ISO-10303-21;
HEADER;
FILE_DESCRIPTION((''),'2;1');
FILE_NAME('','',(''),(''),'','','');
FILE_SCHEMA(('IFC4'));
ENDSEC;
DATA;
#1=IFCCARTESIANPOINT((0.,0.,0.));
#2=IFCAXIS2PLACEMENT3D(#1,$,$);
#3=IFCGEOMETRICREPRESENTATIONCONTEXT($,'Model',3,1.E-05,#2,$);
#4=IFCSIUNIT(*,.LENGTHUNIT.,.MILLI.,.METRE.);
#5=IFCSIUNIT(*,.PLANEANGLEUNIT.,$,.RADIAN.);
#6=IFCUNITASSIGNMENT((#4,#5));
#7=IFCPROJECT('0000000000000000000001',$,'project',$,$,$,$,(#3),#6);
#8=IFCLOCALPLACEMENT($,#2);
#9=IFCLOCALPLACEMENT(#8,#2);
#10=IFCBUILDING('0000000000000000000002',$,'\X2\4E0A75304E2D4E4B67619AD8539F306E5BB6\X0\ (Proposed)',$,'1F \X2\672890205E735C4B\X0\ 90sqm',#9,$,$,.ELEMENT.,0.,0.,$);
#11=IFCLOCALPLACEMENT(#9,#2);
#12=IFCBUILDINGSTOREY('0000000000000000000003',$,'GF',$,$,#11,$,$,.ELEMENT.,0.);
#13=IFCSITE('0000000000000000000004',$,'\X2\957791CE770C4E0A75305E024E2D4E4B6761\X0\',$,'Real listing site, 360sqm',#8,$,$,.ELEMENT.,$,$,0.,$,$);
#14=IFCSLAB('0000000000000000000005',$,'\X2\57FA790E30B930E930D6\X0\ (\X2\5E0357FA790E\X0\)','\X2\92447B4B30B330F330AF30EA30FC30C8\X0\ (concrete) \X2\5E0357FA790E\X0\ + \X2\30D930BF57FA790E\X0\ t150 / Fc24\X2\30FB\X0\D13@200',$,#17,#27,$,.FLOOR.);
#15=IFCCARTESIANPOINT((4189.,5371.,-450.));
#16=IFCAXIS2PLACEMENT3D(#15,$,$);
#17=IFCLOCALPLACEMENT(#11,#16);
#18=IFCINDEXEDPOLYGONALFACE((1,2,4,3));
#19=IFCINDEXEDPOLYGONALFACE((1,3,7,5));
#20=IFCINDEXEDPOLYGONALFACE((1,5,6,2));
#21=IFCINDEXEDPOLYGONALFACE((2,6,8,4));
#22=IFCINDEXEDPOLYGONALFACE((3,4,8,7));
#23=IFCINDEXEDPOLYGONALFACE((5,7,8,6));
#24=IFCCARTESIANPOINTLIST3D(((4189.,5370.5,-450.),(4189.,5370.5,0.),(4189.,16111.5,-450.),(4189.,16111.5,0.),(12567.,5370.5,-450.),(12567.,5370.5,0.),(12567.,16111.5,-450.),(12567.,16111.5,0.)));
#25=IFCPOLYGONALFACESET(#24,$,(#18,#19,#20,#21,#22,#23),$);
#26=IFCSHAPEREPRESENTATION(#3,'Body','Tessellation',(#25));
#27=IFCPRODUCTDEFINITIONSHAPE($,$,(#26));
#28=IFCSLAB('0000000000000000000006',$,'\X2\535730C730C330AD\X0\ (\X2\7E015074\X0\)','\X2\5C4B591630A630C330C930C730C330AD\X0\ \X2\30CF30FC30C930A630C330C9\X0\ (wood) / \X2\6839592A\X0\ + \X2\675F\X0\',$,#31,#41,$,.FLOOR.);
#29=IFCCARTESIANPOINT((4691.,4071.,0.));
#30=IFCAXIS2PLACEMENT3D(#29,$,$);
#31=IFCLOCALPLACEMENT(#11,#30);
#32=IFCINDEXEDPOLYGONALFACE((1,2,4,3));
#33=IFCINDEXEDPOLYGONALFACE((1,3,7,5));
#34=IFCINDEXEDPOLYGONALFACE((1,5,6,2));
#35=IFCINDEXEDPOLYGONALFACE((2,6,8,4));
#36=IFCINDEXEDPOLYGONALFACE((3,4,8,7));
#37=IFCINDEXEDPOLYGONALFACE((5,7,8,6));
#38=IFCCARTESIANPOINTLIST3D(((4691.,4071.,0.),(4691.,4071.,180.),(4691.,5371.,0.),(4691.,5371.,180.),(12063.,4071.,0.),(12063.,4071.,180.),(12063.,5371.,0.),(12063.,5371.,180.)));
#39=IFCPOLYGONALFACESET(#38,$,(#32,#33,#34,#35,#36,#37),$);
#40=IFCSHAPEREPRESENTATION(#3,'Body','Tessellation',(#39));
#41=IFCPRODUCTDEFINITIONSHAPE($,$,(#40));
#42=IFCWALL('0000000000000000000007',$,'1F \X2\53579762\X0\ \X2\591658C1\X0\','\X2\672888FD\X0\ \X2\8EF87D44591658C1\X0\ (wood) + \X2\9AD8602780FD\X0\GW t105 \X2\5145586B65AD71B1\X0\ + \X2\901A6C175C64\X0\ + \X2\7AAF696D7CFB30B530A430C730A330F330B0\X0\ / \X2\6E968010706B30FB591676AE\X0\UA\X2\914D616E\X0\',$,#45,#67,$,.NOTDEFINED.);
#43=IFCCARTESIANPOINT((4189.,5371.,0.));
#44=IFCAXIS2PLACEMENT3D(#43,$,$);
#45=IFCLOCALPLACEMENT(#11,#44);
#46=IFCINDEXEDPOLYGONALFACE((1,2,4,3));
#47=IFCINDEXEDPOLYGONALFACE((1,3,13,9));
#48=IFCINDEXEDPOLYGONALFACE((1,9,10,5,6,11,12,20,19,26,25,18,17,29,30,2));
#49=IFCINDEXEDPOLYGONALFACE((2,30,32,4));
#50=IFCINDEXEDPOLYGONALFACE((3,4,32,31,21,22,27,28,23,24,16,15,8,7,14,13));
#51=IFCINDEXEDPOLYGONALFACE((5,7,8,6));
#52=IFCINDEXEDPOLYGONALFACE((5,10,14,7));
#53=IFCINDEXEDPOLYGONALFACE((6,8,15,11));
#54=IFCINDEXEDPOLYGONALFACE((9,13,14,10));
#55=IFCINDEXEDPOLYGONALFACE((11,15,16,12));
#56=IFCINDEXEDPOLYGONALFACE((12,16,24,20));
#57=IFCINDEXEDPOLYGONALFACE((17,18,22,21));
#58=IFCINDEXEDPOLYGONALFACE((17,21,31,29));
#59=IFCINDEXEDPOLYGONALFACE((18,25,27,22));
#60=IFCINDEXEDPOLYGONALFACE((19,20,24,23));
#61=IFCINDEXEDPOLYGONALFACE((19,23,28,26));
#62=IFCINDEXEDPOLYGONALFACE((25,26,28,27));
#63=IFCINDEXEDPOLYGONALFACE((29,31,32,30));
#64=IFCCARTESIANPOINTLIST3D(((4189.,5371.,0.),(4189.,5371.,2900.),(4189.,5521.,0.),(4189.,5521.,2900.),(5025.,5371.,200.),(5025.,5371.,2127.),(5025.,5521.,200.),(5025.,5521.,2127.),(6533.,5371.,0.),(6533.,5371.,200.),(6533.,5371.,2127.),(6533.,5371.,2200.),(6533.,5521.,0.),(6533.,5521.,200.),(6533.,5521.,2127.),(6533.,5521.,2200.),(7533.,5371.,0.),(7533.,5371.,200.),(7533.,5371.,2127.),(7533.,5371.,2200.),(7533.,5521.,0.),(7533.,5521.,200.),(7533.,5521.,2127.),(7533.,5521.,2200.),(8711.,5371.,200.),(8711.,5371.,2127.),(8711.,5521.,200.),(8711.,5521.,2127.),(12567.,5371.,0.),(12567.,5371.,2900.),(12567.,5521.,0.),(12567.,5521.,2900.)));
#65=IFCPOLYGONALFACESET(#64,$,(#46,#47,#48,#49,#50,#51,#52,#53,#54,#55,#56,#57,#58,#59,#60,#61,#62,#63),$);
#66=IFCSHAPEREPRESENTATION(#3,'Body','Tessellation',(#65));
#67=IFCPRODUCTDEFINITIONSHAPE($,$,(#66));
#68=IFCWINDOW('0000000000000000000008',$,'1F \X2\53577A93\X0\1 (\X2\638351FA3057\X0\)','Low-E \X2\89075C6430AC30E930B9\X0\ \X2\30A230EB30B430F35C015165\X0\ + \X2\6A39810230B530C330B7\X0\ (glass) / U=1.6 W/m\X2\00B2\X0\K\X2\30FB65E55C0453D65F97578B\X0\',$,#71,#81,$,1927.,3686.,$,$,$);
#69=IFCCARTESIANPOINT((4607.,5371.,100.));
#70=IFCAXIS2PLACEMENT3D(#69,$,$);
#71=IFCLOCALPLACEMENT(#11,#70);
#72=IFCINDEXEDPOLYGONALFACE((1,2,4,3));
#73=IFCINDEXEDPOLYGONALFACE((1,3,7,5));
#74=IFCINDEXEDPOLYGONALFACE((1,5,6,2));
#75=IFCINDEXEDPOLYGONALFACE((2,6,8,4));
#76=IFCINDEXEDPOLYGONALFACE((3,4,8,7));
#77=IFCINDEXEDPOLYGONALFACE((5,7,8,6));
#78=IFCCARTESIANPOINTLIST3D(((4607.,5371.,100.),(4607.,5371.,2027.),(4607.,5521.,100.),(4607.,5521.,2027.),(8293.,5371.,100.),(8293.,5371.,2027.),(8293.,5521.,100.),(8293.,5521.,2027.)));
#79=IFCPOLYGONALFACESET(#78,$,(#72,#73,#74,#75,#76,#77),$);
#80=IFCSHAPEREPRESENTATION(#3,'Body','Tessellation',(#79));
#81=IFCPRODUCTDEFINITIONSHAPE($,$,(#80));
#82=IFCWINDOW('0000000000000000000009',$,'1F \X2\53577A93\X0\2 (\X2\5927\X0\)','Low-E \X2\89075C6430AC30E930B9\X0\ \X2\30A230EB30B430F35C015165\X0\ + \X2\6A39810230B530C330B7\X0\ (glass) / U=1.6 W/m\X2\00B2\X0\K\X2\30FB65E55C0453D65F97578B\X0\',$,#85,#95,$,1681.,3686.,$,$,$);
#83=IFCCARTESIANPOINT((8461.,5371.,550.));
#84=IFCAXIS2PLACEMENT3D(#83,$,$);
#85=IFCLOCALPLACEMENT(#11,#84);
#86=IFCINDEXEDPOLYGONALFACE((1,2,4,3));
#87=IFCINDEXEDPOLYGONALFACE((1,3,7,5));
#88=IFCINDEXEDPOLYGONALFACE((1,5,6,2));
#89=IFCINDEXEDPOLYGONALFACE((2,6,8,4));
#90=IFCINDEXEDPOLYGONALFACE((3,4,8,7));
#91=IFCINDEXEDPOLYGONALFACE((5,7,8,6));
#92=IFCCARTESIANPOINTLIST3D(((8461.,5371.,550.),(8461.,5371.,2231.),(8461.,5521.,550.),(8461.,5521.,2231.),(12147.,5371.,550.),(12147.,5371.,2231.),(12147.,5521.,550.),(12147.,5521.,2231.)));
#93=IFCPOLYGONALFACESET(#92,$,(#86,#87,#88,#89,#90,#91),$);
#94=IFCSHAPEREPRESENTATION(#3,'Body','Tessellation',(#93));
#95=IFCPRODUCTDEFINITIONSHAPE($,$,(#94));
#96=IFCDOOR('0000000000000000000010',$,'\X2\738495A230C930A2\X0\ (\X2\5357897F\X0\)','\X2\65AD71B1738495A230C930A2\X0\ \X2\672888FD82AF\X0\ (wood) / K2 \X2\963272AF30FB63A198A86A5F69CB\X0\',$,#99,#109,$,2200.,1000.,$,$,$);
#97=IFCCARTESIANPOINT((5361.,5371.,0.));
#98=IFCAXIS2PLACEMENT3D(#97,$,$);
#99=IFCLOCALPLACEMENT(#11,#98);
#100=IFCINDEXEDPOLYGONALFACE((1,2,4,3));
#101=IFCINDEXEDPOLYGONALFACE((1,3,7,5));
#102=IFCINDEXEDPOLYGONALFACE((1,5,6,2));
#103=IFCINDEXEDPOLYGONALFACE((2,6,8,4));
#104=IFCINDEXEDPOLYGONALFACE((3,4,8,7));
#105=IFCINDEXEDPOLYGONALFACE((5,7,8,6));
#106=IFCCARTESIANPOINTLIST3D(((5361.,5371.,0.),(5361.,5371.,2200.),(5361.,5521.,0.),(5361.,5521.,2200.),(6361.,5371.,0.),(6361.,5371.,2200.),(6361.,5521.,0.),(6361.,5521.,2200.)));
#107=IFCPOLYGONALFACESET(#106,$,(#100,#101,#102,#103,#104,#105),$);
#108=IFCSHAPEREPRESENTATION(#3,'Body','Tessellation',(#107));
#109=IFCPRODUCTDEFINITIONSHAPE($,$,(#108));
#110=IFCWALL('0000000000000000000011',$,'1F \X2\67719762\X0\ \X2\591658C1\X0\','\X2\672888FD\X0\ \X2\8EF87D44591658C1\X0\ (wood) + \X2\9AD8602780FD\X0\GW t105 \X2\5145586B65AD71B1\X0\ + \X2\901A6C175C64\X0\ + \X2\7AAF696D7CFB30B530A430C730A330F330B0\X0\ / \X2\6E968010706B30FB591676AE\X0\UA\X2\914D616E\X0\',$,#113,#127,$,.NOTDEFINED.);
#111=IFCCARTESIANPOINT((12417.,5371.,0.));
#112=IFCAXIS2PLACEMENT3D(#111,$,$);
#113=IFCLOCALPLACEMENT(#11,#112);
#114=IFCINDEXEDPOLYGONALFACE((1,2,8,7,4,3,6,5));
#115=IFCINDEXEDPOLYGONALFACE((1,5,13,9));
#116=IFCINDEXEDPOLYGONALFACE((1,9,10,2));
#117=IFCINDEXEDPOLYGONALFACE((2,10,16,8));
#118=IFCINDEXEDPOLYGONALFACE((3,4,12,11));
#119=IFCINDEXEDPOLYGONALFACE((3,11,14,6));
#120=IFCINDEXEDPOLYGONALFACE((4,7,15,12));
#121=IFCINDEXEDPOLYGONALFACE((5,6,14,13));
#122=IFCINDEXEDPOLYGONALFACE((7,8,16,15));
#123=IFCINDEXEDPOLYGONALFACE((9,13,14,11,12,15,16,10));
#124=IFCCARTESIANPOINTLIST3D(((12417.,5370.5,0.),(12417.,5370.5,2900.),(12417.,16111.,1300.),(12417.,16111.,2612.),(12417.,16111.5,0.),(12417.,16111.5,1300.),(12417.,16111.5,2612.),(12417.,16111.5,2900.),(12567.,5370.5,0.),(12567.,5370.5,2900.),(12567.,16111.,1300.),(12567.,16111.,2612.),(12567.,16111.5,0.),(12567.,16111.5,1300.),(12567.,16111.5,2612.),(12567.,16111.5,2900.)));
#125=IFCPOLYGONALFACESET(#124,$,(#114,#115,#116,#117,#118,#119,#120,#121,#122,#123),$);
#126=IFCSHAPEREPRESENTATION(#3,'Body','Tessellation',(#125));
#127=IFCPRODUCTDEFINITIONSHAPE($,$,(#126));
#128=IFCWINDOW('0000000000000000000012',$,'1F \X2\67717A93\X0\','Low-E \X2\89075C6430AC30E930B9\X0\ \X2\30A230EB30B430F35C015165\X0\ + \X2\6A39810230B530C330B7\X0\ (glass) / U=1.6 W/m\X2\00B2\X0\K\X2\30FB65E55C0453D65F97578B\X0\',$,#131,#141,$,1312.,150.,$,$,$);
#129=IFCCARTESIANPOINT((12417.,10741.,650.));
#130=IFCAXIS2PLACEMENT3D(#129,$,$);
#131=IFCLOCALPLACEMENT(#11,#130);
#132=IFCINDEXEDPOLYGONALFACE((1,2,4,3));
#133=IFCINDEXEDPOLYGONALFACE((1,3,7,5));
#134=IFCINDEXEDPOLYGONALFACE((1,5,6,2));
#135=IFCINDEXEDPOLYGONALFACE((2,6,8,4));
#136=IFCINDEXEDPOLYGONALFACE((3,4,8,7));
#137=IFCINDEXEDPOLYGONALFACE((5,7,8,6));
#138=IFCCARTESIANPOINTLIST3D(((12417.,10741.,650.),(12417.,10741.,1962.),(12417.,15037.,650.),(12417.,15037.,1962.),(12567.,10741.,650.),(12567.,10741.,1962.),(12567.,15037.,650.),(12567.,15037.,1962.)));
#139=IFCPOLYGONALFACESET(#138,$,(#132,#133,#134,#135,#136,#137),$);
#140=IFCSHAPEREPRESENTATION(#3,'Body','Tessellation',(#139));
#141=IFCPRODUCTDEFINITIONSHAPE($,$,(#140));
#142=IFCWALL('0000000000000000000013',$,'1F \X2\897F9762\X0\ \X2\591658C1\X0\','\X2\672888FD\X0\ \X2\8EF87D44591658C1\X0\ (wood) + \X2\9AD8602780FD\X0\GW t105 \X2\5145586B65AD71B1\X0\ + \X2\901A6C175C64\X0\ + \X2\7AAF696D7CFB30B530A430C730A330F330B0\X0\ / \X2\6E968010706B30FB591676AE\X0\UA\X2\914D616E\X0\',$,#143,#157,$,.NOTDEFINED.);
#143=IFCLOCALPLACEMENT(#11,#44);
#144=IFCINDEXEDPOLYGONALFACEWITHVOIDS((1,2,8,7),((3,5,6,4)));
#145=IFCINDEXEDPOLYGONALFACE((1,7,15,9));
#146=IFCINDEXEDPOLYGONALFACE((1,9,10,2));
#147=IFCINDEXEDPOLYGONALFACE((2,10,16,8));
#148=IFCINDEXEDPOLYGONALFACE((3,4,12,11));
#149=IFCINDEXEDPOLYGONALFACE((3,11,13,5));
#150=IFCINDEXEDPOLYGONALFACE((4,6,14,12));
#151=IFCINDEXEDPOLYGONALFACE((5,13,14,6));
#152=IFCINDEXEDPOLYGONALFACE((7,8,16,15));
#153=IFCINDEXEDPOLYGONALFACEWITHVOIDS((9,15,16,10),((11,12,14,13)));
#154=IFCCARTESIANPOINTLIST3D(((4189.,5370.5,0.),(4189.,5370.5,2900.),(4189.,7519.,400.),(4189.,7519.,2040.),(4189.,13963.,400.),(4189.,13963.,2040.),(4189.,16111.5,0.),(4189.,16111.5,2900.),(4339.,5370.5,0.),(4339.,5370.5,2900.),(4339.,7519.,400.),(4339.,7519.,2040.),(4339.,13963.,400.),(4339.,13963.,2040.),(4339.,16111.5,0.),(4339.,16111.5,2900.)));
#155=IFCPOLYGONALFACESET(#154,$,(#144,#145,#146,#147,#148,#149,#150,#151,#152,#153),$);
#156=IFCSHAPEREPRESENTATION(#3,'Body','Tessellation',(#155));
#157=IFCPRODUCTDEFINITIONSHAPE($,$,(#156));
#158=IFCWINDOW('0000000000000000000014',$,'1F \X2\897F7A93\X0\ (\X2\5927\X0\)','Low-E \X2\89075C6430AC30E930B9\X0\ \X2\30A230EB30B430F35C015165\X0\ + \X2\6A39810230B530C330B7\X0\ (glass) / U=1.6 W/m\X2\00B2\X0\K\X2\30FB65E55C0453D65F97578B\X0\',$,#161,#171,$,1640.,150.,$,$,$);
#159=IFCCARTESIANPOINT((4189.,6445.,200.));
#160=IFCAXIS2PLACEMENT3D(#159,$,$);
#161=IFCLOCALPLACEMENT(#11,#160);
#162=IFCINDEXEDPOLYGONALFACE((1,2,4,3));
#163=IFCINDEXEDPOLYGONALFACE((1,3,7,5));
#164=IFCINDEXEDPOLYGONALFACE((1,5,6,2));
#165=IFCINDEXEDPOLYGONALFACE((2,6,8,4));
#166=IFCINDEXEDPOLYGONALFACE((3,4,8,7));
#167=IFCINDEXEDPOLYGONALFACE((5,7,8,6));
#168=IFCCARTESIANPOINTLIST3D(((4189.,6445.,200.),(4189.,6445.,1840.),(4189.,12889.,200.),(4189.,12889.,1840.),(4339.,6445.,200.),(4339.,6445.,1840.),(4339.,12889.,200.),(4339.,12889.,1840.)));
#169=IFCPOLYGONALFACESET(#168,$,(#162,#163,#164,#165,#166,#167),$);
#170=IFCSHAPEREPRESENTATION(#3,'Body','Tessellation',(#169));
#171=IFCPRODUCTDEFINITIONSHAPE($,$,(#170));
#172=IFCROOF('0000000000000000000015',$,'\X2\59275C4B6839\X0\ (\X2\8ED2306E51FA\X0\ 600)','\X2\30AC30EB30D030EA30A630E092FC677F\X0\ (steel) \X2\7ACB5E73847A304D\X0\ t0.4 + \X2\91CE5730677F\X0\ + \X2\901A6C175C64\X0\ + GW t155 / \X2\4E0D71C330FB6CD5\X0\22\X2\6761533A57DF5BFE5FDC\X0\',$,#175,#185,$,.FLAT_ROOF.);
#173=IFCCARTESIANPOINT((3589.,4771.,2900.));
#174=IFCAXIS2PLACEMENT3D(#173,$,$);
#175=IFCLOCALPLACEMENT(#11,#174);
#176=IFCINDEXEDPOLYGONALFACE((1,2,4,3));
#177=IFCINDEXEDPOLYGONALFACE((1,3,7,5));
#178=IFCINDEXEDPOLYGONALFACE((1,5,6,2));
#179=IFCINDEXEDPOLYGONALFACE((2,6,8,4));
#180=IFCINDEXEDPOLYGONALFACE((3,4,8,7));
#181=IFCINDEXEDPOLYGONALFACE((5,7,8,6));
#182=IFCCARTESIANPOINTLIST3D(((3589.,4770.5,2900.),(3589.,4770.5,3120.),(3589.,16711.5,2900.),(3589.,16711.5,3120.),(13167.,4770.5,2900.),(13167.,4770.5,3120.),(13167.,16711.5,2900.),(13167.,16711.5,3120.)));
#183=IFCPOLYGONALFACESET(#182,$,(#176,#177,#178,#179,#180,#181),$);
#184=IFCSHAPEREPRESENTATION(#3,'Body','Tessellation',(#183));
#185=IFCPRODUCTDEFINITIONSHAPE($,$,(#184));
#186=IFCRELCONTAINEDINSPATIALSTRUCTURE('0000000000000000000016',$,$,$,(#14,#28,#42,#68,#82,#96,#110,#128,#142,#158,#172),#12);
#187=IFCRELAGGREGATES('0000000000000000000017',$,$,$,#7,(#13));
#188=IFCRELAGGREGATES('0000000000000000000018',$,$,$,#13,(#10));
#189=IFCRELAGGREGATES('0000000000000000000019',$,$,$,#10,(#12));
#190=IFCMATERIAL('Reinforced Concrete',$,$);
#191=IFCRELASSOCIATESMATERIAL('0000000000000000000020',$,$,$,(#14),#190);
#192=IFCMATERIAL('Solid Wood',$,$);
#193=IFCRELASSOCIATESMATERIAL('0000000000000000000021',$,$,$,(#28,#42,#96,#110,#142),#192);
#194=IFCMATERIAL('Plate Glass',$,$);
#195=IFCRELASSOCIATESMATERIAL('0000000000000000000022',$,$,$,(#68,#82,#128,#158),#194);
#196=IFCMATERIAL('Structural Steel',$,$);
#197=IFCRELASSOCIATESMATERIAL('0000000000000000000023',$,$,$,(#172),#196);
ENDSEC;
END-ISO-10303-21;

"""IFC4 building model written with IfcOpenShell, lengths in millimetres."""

from ifc_helpers import new_model, si_unit, frame, frame_2d, origin, place, context, project, spatial, rectangle, extrude, material, element, fill, save


model = new_model("IFC4")

# Units and contexts
model_context = context("Model", 3, precision=1e-05, world=origin())
ifc_project = project(units=[si_unit("LENGTHUNIT", "METRE", prefix="MILLI"), si_unit("PLANEANGLEUNIT", "RADIAN")], contexts=[model_context])

# Site, building, storey
site_placement = place(None, origin())
site = spatial("IfcSite", under=ifc_project, at=site_placement, Name="長野県上田市中之条", ObjectType="Real listing site, 360sqm", CompositionType="ELEMENT", RefElevation=0.0)
building_placement = place(site_placement, origin())
building = spatial("IfcBuilding", under=site, at=building_placement, Name="上田中之条高原の家 (Proposed)", ObjectType="1F 木造平屋 90sqm", CompositionType="ELEMENT", ElevationOfRefHeight=0.0, ElevationOfTerrain=0.0)
storey_placement = place(building_placement, origin())
storey = spatial("IfcBuildingStorey", under=building, at=storey_placement, Name="GF", CompositionType="ELEMENT", Elevation=0.0)

# Slabs
ifc_material_1 = material(Name="Reinforced Concrete")
slab_1_placement = place(storey_placement, frame((4189.0, 5371.0, -450.0)))
element("IfcSlab", 1, at=slab_1_placement, inside=storey, material=ifc_material_1, Name="基礎スラブ (布基礎)", Description="鉄筋コンクリート (concrete) 布基礎 + ベタ基礎 t150 / Fc24・D13@200", PredefinedType="FLOOR", context=model_context, shape_type="SweptSolid", body=[
    extrude(rectangle(XDim=8378.0, YDim=10741.0, at=frame_2d((4189.0, 5370.0))), frame((4189.0, 5371.0, -450.0)), (0.0, 0.0, 1.0), 450.0),
])
ifc_material_2 = material(Name="Solid Wood")
slab_2_placement = place(storey_placement, frame((4691.0, 4071.0, 0.0)))
element("IfcSlab", 2, at=slab_2_placement, inside=storey, material=ifc_material_2, Name="南デッキ (縁側)", Description="屋外ウッドデッキ ハードウッド (wood) / 根太 + 束", PredefinedType="FLOOR", context=model_context, shape_type="SweptSolid", body=[
    extrude(rectangle(XDim=7372.0, YDim=1300.0, at=frame_2d((3686.0, 650.0))), frame((4691.0, 4071.0, 0.0)), (0.0, 0.0, 1.0), 180.0),
])

# Wall, openings, windows, door
wall_1_placement = place(storey_placement, frame((4189.0, 5371.0, 0.0)))
wall_1 = element("IfcWall", 3, at=wall_1_placement, inside=storey, material=ifc_material_2, Name="1F 南面 外壁", Description="木製 軸組外壁 (wood) + 高性能GW t105 充填断熱 + 通気層 + 窯業系サイディング / 準耐火・外皮UA配慮", PredefinedType="NOTDEFINED", context=model_context, shape_type="SweptSolid", body=[
    extrude(rectangle(XDim=8378.0, YDim=150.0, at=frame_2d((4189.0, 75.0))), frame((4189.0, 5371.0, 0.0)), (0.0, 0.0, 1.0), 2900.0),
])
opening_1_placement = place(storey_placement, frame((4607.0, 5371.0, 100.0)))
opening_1 = element("IfcOpeningElement", 4, at=opening_1_placement, cuts=wall_1, PredefinedType="NOTDEFINED", context=model_context, shape_type="SweptSolid", body=[
    extrude(rectangle(XDim=3686.0, YDim=150.0, at=frame_2d((1843.0, 75.0))), frame((4607.0, 5371.0, 100.0)), (0.0, 0.0, 1.0), 1927.0),
])
opening_2_placement = place(storey_placement, frame((8461.0, 5371.0, 550.0)))
opening_2 = element("IfcOpeningElement", 5, at=opening_2_placement, cuts=wall_1, PredefinedType="NOTDEFINED", context=model_context, shape_type="SweptSolid", body=[
    extrude(rectangle(XDim=3686.0, YDim=150.0, at=frame_2d((1843.0, 75.0))), frame((8461.0, 5371.0, 550.0)), (0.0, 0.0, 1.0), 1681.0),
])
opening_3_placement = place(storey_placement, frame((5361.0, 5371.0, 0.0)))
opening_3 = element("IfcOpeningElement", 6, at=opening_3_placement, cuts=wall_1, PredefinedType="NOTDEFINED", context=model_context, shape_type="SweptSolid", body=[
    extrude(rectangle(XDim=1000.0, YDim=150.0, at=frame_2d((500.0, 75.0))), frame((5361.0, 5371.0, 0.0)), (0.0, 0.0, 1.0), 2200.0),
])
ifc_material_3 = material(Name="Plate Glass")
window_1_placement = place(storey_placement, frame((4607.0, 5371.0, 100.0)))
window_1 = element("IfcWindow", 7, at=window_1_placement, inside=storey, material=ifc_material_3, Name="1F 南窓1 (掃出し)", Description="Low-E 複層ガラス アルゴン封入 + 樹脂サッシ (glass) / U=1.6 W/m²K・日射取得型", OverallHeight=1927.0, OverallWidth=3686.0, context=model_context, shape_type="SweptSolid", body=[
    extrude(rectangle(XDim=3686.0, YDim=150.0, at=frame_2d((1843.0, 75.0))), frame((4607.0, 5371.0, 100.0)), (0.0, 0.0, 1.0), 1927.0),
])
fill(opening_1, window_1)
window_2_placement = place(storey_placement, frame((8461.0, 5371.0, 550.0)))
window_2 = element("IfcWindow", 8, at=window_2_placement, inside=storey, material=ifc_material_3, Name="1F 南窓2 (大)", Description="Low-E 複層ガラス アルゴン封入 + 樹脂サッシ (glass) / U=1.6 W/m²K・日射取得型", OverallHeight=1681.0, OverallWidth=3686.0, context=model_context, shape_type="SweptSolid", body=[
    extrude(rectangle(XDim=3686.0, YDim=150.0, at=frame_2d((1843.0, 75.0))), frame((8461.0, 5371.0, 550.0)), (0.0, 0.0, 1.0), 1681.0),
])
fill(opening_2, window_2)
door_placement = place(storey_placement, frame((5361.0, 5371.0, 0.0)))
door = element("IfcDoor", 9, at=door_placement, inside=storey, material=ifc_material_2, Name="玄関ドア (南西)", Description="断熱玄関ドア 木製芯 (wood) / K2 防犯・採風機構", OverallHeight=2200.0, OverallWidth=1000.0, context=model_context, shape_type="SweptSolid", body=[
    extrude(rectangle(XDim=1000.0, YDim=150.0, at=frame_2d((500.0, 75.0))), frame((5361.0, 5371.0, 0.0)), (0.0, 0.0, 1.0), 2200.0),
])
fill(opening_3, door)

# Walls, openings, windows
wall_2_placement = place(storey_placement, frame((12417.0, 5371.0, 0.0)))
wall_2 = element("IfcWall", 10, at=wall_2_placement, inside=storey, material=ifc_material_2, Name="1F 東面 外壁", Description="木製 軸組外壁 (wood) + 高性能GW t105 充填断熱 + 通気層 + 窯業系サイディング / 準耐火・外皮UA配慮", PredefinedType="NOTDEFINED", context=model_context, shape_type="SweptSolid", body=[
    extrude(rectangle(XDim=150.0, YDim=10741.0, at=frame_2d((75.0, 5370.0))), frame((12417.0, 5371.0, 0.0)), (0.0, 0.0, 1.0), 2900.0),
])
opening_4_placement = place(storey_placement, frame((12417.0, 10741.0, 650.0)))
opening_4 = element("IfcOpeningElement", 11, at=opening_4_placement, cuts=wall_2, PredefinedType="NOTDEFINED", context=model_context, shape_type="SweptSolid", body=[
    extrude(rectangle(XDim=150.0, YDim=4296.0, at=frame_2d((75.0, 2148.0))), frame((12417.0, 10741.0, 650.0)), (0.0, 0.0, 1.0), 1312.0),
])
window_3_placement = place(storey_placement, frame((12417.0, 10741.0, 650.0)))
window_3 = element("IfcWindow", 12, at=window_3_placement, inside=storey, material=ifc_material_3, Name="1F 東窓", Description="Low-E 複層ガラス アルゴン封入 + 樹脂サッシ (glass) / U=1.6 W/m²K・日射取得型", OverallHeight=1312.0, OverallWidth=150.0, context=model_context, shape_type="SweptSolid", body=[
    extrude(rectangle(XDim=150.0, YDim=4296.0, at=frame_2d((75.0, 2148.0))), frame((12417.0, 10741.0, 650.0)), (0.0, 0.0, 1.0), 1312.0),
])
fill(opening_4, window_3)
wall_3_placement = place(storey_placement, frame((4189.0, 5371.0, 0.0)))
wall_3 = element("IfcWall", 13, at=wall_3_placement, inside=storey, material=ifc_material_2, Name="1F 西面 外壁", Description="木製 軸組外壁 (wood) + 高性能GW t105 充填断熱 + 通気層 + 窯業系サイディング / 準耐火・外皮UA配慮", PredefinedType="NOTDEFINED", context=model_context, shape_type="SweptSolid", body=[
    extrude(rectangle(XDim=150.0, YDim=10741.0, at=frame_2d((75.0, 5370.0))), frame((4189.0, 5371.0, 0.0)), (0.0, 0.0, 1.0), 2900.0),
])
opening_5_placement = place(storey_placement, frame((4189.0, 6445.0, 200.0)))
opening_5 = element("IfcOpeningElement", 14, at=opening_5_placement, cuts=wall_3, PredefinedType="NOTDEFINED", context=model_context, shape_type="SweptSolid", body=[
    extrude(rectangle(XDim=150.0, YDim=6444.0, at=frame_2d((75.0, 3222.0))), frame((4189.0, 6445.0, 200.0)), (0.0, 0.0, 1.0), 1640.0),
])
window_4_placement = place(storey_placement, frame((4189.0, 6445.0, 200.0)))
window_4 = element("IfcWindow", 15, at=window_4_placement, inside=storey, material=ifc_material_3, Name="1F 西窓 (大)", Description="Low-E 複層ガラス アルゴン封入 + 樹脂サッシ (glass) / U=1.6 W/m²K・日射取得型", OverallHeight=1640.0, OverallWidth=150.0, context=model_context, shape_type="SweptSolid", body=[
    extrude(rectangle(XDim=150.0, YDim=6444.0, at=frame_2d((75.0, 3222.0))), frame((4189.0, 6445.0, 200.0)), (0.0, 0.0, 1.0), 1640.0),
])
fill(opening_5, window_4)

# Roof
ifc_material_4 = material(Name="Structural Steel")
roof_placement = place(storey_placement, frame((3589.0, 4771.0, 2900.0)))
element("IfcRoof", 16, at=roof_placement, inside=storey, material=ifc_material_4, Name="大屋根 (軒の出 600)", Description="ガルバリウム鋼板 (steel) 立平葺き t0.4 + 野地板 + 通気層 + GW t155 / 不燃・法22条区域対応", PredefinedType="FLAT_ROOF", context=model_context, shape_type="SweptSolid", body=[
    extrude(rectangle(XDim=9578.0, YDim=11941.0, at=frame_2d((4789.0, 5970.0))), frame((3589.0, 4771.0, 2900.0)), (0.0, 0.0, 1.0), 220.0),
])

save(model, "model.ifc")
